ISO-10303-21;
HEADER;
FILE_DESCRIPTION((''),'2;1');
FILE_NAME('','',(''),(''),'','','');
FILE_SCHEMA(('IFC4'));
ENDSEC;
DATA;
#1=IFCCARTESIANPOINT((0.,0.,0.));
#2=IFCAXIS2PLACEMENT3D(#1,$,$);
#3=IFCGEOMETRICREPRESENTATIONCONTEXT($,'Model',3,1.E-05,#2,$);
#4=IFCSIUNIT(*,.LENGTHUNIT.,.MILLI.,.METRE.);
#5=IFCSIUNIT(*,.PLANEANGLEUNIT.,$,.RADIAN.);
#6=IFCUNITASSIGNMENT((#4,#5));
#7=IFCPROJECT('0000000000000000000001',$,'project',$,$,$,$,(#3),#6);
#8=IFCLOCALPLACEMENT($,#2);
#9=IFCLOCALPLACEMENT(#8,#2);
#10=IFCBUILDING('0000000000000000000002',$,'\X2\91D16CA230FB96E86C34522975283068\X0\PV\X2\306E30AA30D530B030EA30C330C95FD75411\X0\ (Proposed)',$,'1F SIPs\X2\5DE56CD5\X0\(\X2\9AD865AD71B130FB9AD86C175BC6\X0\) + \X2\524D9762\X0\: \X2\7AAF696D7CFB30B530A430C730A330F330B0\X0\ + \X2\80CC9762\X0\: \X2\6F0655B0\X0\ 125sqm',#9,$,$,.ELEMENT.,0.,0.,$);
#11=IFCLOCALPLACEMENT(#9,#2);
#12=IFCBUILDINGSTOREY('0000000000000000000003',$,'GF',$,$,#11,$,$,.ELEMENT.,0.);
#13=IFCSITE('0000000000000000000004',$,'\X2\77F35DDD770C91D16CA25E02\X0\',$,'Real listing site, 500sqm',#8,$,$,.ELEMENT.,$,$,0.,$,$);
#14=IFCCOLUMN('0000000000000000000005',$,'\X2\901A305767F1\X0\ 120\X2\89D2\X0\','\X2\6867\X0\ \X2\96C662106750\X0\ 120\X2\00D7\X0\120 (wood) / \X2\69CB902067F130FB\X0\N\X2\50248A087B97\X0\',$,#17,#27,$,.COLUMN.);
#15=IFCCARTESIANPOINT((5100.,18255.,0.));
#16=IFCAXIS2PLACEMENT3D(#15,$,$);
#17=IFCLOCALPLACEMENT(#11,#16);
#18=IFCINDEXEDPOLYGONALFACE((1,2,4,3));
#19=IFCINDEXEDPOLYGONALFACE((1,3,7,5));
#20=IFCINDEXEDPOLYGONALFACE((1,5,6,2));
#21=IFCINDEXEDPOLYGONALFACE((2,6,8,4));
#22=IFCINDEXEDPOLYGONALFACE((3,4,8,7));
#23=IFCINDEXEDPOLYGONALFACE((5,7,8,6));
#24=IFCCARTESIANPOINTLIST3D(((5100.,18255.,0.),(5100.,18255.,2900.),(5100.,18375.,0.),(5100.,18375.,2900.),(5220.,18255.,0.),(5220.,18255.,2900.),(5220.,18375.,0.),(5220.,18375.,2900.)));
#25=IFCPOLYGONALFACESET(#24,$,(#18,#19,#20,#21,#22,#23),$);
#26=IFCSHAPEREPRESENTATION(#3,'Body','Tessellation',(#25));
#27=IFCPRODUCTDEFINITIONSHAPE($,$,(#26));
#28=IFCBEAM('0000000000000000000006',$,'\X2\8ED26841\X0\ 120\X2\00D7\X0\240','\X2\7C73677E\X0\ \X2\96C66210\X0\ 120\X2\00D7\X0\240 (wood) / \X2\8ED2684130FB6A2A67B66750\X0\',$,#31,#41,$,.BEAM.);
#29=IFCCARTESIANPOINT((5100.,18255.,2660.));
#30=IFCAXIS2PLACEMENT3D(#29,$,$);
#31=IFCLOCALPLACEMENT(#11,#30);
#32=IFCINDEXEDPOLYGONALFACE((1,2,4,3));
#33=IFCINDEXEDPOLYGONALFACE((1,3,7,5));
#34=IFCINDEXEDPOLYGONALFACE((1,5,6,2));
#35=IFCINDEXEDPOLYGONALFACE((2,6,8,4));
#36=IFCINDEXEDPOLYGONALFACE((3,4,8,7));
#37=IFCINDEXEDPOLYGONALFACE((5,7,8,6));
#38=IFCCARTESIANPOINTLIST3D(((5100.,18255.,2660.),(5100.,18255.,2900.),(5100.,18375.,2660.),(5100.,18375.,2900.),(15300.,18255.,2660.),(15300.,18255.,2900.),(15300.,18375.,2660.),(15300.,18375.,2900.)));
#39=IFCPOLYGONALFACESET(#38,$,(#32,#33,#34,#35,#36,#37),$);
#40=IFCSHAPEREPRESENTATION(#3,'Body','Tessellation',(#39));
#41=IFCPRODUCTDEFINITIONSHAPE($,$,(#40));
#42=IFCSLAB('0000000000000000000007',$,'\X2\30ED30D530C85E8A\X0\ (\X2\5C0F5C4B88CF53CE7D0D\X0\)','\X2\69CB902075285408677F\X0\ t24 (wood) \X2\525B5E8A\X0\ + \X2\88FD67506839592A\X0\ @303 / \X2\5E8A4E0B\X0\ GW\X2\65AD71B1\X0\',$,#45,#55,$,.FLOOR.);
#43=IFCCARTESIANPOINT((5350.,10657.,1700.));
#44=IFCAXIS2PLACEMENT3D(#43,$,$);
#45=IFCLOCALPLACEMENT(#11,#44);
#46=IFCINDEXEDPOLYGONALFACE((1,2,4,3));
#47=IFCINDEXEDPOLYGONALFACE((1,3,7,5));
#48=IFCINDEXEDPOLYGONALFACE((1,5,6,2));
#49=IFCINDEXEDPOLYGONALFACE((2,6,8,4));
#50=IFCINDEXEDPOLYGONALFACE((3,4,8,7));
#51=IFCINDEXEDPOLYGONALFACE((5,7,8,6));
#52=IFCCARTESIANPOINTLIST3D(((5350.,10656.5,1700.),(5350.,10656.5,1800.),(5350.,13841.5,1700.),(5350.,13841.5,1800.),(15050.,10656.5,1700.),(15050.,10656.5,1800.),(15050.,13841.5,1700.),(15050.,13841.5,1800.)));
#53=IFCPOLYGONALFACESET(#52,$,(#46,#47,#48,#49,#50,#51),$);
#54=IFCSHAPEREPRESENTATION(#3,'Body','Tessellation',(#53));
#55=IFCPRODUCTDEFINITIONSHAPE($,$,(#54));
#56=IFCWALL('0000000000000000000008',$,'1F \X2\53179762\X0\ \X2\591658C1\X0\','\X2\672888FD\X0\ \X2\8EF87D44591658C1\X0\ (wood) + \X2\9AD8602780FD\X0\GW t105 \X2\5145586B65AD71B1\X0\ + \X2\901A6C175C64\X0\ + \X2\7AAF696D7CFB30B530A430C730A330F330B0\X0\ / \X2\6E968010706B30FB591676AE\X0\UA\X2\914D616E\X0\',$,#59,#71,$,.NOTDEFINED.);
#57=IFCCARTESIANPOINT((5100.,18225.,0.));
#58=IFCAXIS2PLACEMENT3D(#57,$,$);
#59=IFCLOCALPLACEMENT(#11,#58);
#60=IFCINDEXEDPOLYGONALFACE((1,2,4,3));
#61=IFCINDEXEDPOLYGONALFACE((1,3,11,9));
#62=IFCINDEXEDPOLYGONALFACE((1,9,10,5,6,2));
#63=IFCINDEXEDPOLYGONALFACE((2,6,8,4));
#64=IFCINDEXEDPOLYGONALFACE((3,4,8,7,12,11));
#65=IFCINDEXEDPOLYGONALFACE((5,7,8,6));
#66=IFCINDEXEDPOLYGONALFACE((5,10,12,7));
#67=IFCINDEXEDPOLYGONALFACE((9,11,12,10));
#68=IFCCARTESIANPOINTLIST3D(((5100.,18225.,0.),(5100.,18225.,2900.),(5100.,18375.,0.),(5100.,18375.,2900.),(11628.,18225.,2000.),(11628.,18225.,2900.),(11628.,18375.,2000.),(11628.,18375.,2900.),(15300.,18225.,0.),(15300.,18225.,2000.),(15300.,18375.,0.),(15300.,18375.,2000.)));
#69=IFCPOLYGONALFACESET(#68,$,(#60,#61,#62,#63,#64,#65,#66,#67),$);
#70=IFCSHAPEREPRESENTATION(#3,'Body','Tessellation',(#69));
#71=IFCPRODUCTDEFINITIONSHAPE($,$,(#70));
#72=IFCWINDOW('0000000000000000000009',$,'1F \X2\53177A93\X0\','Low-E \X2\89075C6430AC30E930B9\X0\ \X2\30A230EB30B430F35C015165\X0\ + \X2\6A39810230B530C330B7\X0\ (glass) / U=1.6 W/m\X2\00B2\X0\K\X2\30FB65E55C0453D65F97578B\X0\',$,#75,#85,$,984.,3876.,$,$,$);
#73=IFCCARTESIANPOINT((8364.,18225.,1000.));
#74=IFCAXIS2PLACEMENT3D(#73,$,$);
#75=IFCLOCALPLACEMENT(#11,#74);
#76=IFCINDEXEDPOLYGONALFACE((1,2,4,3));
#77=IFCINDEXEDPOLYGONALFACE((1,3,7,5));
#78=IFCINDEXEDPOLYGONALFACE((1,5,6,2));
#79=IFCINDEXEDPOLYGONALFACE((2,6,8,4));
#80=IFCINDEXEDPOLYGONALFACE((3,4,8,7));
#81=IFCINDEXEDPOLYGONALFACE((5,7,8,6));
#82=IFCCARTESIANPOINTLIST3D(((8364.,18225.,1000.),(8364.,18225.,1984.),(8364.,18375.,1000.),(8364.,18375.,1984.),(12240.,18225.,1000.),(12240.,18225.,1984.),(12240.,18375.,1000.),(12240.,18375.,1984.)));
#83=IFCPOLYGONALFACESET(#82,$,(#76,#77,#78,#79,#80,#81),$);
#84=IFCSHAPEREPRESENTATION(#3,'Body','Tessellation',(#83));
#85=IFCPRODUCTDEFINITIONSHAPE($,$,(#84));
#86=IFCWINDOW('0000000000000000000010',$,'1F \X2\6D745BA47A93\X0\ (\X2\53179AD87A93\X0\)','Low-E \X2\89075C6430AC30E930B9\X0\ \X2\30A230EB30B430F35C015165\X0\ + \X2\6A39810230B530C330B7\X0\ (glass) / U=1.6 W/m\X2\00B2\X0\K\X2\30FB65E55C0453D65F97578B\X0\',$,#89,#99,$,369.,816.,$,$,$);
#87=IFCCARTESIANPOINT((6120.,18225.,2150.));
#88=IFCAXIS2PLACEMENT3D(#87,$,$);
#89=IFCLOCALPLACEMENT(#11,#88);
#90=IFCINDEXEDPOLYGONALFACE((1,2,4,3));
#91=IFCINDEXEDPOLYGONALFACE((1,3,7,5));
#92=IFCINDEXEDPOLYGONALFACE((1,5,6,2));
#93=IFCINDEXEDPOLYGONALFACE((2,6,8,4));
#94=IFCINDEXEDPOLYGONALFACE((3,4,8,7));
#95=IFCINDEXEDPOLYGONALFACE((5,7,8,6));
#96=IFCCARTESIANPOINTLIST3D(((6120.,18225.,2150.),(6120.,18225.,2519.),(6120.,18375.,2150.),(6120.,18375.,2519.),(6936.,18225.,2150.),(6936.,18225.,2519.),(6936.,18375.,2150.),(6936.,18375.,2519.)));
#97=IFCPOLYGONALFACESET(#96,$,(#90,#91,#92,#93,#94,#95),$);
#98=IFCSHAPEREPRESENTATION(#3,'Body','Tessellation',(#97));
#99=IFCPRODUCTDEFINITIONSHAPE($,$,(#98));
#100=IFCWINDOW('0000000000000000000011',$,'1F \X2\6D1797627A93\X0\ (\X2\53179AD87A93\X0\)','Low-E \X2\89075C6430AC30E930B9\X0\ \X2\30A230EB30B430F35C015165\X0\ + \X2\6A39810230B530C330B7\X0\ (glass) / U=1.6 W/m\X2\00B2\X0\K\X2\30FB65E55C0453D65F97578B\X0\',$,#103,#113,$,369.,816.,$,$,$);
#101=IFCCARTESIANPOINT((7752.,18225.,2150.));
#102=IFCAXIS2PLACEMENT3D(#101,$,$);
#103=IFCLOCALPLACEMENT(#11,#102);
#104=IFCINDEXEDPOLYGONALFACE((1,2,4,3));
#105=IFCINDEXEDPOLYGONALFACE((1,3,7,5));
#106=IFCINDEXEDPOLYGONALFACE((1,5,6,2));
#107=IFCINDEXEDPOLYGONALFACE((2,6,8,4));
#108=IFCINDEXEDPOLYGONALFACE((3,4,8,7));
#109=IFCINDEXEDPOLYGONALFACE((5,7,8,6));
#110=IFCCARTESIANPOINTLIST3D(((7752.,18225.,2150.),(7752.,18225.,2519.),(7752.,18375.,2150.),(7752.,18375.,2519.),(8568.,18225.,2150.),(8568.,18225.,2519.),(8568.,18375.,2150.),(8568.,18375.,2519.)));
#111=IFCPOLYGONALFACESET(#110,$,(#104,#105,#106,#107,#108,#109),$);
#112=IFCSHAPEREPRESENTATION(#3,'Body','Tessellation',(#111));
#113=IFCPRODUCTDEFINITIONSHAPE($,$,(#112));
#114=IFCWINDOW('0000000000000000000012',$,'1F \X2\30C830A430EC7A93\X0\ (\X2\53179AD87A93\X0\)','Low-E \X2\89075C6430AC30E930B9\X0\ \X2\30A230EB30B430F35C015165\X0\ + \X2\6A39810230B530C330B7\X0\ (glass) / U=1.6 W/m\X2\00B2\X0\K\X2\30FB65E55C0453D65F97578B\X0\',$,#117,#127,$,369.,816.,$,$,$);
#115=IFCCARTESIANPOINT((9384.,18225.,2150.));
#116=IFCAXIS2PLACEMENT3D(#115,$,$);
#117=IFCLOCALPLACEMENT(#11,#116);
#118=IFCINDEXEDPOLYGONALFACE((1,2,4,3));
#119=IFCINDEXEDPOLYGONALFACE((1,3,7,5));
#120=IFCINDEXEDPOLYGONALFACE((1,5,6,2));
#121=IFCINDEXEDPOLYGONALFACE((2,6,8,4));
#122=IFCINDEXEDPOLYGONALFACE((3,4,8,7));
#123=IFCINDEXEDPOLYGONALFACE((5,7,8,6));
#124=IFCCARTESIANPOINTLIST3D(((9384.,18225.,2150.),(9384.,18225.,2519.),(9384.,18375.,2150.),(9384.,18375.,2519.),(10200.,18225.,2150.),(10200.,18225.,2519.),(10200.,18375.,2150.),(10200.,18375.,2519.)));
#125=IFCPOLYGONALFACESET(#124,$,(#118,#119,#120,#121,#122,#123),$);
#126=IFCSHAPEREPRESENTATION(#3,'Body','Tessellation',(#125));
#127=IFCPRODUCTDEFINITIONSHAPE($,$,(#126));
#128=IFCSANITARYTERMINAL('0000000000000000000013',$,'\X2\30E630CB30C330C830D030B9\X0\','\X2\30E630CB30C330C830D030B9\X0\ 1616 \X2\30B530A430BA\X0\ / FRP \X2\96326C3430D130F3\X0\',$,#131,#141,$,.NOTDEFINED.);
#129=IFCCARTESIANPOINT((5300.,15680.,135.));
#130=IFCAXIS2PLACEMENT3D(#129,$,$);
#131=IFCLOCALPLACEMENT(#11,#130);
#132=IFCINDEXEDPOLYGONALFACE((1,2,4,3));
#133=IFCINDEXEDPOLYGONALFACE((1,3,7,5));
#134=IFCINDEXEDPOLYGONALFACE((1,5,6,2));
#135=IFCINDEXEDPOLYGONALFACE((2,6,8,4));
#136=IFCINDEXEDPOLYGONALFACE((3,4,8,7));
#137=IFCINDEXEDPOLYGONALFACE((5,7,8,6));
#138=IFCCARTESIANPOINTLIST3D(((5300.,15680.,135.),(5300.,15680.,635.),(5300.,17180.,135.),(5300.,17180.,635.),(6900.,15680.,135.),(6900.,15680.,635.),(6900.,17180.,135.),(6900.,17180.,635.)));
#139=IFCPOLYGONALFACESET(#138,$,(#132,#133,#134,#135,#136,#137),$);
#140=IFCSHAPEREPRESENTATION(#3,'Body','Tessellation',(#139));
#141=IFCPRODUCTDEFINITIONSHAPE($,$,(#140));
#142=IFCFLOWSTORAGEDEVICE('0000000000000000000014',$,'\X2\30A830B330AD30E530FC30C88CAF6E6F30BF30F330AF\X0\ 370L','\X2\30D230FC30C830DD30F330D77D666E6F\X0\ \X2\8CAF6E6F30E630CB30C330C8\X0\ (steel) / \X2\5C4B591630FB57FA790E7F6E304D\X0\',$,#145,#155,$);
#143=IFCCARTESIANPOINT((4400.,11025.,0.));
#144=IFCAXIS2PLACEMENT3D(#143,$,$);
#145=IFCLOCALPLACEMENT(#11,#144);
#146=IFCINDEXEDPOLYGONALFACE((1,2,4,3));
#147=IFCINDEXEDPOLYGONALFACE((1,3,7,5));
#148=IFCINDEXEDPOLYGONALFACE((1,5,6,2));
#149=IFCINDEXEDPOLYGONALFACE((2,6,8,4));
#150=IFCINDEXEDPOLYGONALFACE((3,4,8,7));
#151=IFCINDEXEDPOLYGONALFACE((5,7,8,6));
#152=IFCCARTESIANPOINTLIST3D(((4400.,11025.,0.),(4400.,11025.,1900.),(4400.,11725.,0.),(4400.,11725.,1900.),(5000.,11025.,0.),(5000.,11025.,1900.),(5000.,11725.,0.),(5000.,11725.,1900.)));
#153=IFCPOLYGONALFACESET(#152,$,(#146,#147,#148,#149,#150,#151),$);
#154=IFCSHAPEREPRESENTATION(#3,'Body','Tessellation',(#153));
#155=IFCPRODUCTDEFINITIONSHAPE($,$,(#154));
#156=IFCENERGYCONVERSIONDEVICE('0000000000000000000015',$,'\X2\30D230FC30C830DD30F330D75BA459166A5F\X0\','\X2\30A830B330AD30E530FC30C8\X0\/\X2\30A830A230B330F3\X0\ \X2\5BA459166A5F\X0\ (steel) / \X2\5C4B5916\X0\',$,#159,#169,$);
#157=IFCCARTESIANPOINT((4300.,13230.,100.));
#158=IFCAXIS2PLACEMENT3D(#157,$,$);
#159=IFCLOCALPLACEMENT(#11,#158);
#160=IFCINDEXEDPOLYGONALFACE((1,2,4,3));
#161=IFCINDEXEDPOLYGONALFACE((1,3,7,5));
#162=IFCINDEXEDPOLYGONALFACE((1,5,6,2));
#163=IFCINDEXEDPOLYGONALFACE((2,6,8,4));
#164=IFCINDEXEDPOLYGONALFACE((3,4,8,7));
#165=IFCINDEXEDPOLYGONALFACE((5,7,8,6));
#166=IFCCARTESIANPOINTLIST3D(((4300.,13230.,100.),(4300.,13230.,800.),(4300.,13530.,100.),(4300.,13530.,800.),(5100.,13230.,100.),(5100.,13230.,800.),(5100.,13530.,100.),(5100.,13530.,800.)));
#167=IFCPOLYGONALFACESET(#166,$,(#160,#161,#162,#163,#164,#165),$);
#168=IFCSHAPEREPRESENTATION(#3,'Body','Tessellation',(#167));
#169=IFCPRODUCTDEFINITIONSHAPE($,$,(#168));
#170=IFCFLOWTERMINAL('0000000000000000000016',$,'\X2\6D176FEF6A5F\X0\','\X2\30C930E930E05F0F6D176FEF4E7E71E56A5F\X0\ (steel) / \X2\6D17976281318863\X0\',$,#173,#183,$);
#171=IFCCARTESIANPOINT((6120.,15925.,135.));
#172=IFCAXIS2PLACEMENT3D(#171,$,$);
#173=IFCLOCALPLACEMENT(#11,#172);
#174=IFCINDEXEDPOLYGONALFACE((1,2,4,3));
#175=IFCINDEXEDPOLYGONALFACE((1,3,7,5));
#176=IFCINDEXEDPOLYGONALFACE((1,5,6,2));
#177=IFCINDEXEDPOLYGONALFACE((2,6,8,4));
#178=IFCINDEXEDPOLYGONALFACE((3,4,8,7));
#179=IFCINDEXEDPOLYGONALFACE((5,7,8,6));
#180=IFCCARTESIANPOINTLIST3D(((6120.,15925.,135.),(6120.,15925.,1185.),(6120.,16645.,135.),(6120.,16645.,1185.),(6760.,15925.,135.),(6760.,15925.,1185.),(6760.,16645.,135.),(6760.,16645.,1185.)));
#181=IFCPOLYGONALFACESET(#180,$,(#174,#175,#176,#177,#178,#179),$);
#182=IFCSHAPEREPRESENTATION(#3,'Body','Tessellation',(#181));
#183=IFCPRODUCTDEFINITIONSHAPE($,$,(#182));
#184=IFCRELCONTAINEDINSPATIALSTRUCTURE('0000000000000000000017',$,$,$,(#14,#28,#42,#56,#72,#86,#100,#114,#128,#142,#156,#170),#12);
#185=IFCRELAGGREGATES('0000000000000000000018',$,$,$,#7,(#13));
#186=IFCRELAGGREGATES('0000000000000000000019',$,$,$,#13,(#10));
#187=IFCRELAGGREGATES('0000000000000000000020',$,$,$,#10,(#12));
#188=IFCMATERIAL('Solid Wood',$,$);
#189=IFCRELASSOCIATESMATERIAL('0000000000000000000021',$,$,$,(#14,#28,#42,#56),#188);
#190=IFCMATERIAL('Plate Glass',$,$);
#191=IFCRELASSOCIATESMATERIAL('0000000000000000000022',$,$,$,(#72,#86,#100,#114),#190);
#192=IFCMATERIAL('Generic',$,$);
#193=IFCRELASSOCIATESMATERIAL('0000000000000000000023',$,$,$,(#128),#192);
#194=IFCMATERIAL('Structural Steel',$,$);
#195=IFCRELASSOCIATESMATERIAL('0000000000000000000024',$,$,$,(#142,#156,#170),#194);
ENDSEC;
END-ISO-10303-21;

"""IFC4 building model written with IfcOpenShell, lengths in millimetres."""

from ifc_helpers import new_model, si_unit, frame, frame_2d, origin, place, context, project, spatial, rectangle, extrude, material, element, fill, save


model = new_model("IFC4")

# Units and contexts
model_context = context("Model", 3, precision=1e-05, world=origin())
ifc_project = project(units=[si_unit("LENGTHUNIT", "METRE", prefix="MILLI"), si_unit("PLANEANGLEUNIT", "RADIAN")], contexts=[model_context])

# Site, building, storey
site_placement = place(None, origin())
site = spatial("IfcSite", under=ifc_project, at=site_placement, Name="石川県金沢市", ObjectType="Real listing site, 500sqm", CompositionType="ELEMENT", RefElevation=0.0)
building_placement = place(site_placement, origin())
building = spatial("IfcBuilding", under=site, at=building_placement, Name="金沢・雨水利用とPVのオフグリッド志向 (Proposed)", ObjectType="1F SIPs工法(高断熱・高気密) + 前面: 窯業系サイディング + 背面: 漆喰 125sqm", CompositionType="ELEMENT", ElevationOfRefHeight=0.0, ElevationOfTerrain=0.0)
storey_placement = place(building_placement, origin())
storey = spatial("IfcBuildingStorey", under=building, at=storey_placement, Name="GF", CompositionType="ELEMENT", Elevation=0.0)

# Column
ifc_material_1 = material(Name="Solid Wood")
column_1_placement = place(storey_placement, frame((5100.0, 18255.0, 0.0)))
element("IfcColumn", 1, at=column_1_placement, inside=storey, material=ifc_material_1, Name="通し柱 120角", Description="桧 集成材 120×120 (wood) / 構造柱・N値計算", PredefinedType="COLUMN", context=model_context, shape_type="SweptSolid", body=[
    extrude(rectangle(XDim=120.0, YDim=120.0, at=frame_2d((60.0, 60.0))), frame((5100.0, 18255.0, 0.0)), (0.0, 0.0, 1.0), 2900.0),
])

# Beam
beam_1_placement = place(storey_placement, frame((5100.0, 18255.0, 2660.0)))
element("IfcBeam", 2, at=beam_1_placement, inside=storey, material=ifc_material_1, Name="軒桁 120×240", Description="米松 集成 120×240 (wood) / 軒桁・横架材", PredefinedType="BEAM", context=model_context, shape_type="SweptSolid", body=[
    extrude(rectangle(XDim=10200.0, YDim=120.0, at=frame_2d((5100.0, 60.0))), frame((5100.0, 18255.0, 2660.0)), (0.0, 0.0, 1.0), 240.0),
])

# Slab
slab_placement = place(storey_placement, frame((5350.0, 10657.0, 1700.0)))
element("IfcSlab", 3, at=slab_placement, inside=storey, material=ifc_material_1, Name="ロフト床 (小屋裏収納)", Description="構造用合板 t24 (wood) 剛床 + 製材根太 @303 / 床下 GW断熱", PredefinedType="FLOOR", context=model_context, shape_type="SweptSolid", body=[
    extrude(rectangle(XDim=9700.0, YDim=3185.0, at=frame_2d((4850.0, 1592.0))), frame((5350.0, 10657.0, 1700.0)), (0.0, 0.0, 1.0), 100.0),
])

# Wall, openings, windows
wall_1_placement = place(storey_placement, frame((5100.0, 18225.0, 0.0)))
wall_1 = element("IfcWall", 4, at=wall_1_placement, inside=storey, material=ifc_material_1, Name="1F 北面 外壁", Description="木製 軸組外壁 (wood) + 高性能GW t105 充填断熱 + 通気層 + 窯業系サイディング / 準耐火・外皮UA配慮", PredefinedType="NOTDEFINED", context=model_context, shape_type="SweptSolid", body=[
    extrude(rectangle(XDim=10200.0, YDim=150.0, at=frame_2d((5100.0, 75.0))), frame((5100.0, 18225.0, 0.0)), (0.0, 0.0, 1.0), 2900.0),
])
opening_1_placement = place(storey_placement, frame((8364.0, 18225.0, 1000.0)))
opening_1 = element("IfcOpeningElement", 5, at=opening_1_placement, cuts=wall_1, PredefinedType="NOTDEFINED", context=model_context, shape_type="SweptSolid", body=[
    extrude(rectangle(XDim=3876.0, YDim=150.0, at=frame_2d((1938.0, 75.0))), frame((8364.0, 18225.0, 1000.0)), (0.0, 0.0, 1.0), 984.0),
])
opening_2_placement = place(storey_placement, frame((6120.0, 18225.0, 2150.0)))
opening_2 = element("IfcOpeningElement", 6, at=opening_2_placement, cuts=wall_1, PredefinedType="NOTDEFINED", context=model_context, shape_type="SweptSolid", body=[
    extrude(rectangle(XDim=816.0, YDim=150.0, at=frame_2d((408.0, 75.0))), frame((6120.0, 18225.0, 2150.0)), (0.0, 0.0, 1.0), 369.0),
])
opening_3_placement = place(storey_placement, frame((7752.0, 18225.0, 2150.0)))
opening_3 = element("IfcOpeningElement", 7, at=opening_3_placement, cuts=wall_1, PredefinedType="NOTDEFINED", context=model_context, shape_type="SweptSolid", body=[
    extrude(rectangle(XDim=816.0, YDim=150.0, at=frame_2d((408.0, 75.0))), frame((7752.0, 18225.0, 2150.0)), (0.0, 0.0, 1.0), 369.0),
])
opening_4_placement = place(storey_placement, frame((9384.0, 18225.0, 2150.0)))
opening_4 = element("IfcOpeningElement", 8, at=opening_4_placement, cuts=wall_1, PredefinedType="NOTDEFINED", context=model_context, shape_type="SweptSolid", body=[
    extrude(rectangle(XDim=816.0, YDim=150.0, at=frame_2d((408.0, 75.0))), frame((9384.0, 18225.0, 2150.0)), (0.0, 0.0, 1.0), 369.0),
])
ifc_material_2 = material(Name="Plate Glass")
window_1_placement = place(storey_placement, frame((8364.0, 18225.0, 1000.0)))
window_1 = element("IfcWindow", 9, at=window_1_placement, inside=storey, material=ifc_material_2, Name="1F 北窓", Description="Low-E 複層ガラス アルゴン封入 + 樹脂サッシ (glass) / U=1.6 W/m²K・日射取得型", OverallHeight=984.0, OverallWidth=3876.0, context=model_context, shape_type="SweptSolid", body=[
    extrude(rectangle(XDim=3876.0, YDim=150.0, at=frame_2d((1938.0, 75.0))), frame((8364.0, 18225.0, 1000.0)), (0.0, 0.0, 1.0), 984.0),
])
fill(opening_1, window_1)
window_2_placement = place(storey_placement, frame((6120.0, 18225.0, 2150.0)))
window_2 = element("IfcWindow", 10, at=window_2_placement, inside=storey, material=ifc_material_2, Name="1F 浴室窓 (北高窓)", Description="Low-E 複層ガラス アルゴン封入 + 樹脂サッシ (glass) / U=1.6 W/m²K・日射取得型", OverallHeight=369.0, OverallWidth=816.0, context=model_context, shape_type="SweptSolid", body=[
    extrude(rectangle(XDim=816.0, YDim=150.0, at=frame_2d((408.0, 75.0))), frame((6120.0, 18225.0, 2150.0)), (0.0, 0.0, 1.0), 369.0),
])
fill(opening_2, window_2)
window_3_placement = place(storey_placement, frame((7752.0, 18225.0, 2150.0)))
window_3 = element("IfcWindow", 11, at=window_3_placement, inside=storey, material=ifc_material_2, Name="1F 洗面窓 (北高窓)", Description="Low-E 複層ガラス アルゴン封入 + 樹脂サッシ (glass) / U=1.6 W/m²K・日射取得型", OverallHeight=369.0, OverallWidth=816.0, context=model_context, shape_type="SweptSolid", body=[
    extrude(rectangle(XDim=816.0, YDim=150.0, at=frame_2d((408.0, 75.0))), frame((7752.0, 18225.0, 2150.0)), (0.0, 0.0, 1.0), 369.0),
])
fill(opening_3, window_3)
window_4_placement = place(storey_placement, frame((9384.0, 18225.0, 2150.0)))
window_4 = element("IfcWindow", 12, at=window_4_placement, inside=storey, material=ifc_material_2, Name="1F トイレ窓 (北高窓)", Description="Low-E 複層ガラス アルゴン封入 + 樹脂サッシ (glass) / U=1.6 W/m²K・日射取得型", OverallHeight=369.0, OverallWidth=816.0, context=model_context, shape_type="SweptSolid", body=[
    extrude(rectangle(XDim=816.0, YDim=150.0, at=frame_2d((408.0, 75.0))), frame((9384.0, 18225.0, 2150.0)), (0.0, 0.0, 1.0), 369.0),
])
fill(opening_4, window_4)

# Sanitary terminal
ifc_material_3 = material(Name="Generic")
sanitary_terminal_placement = place(storey_placement, frame((5300.0, 15680.0, 135.0)))
element("IfcSanitaryTerminal", 13, at=sanitary_terminal_placement, inside=storey, material=ifc_material_3, Name="ユニットバス", Description="ユニットバス 1616 サイズ / FRP 防水パン", PredefinedType="NOTDEFINED", context=model_context, shape_type="SweptSolid", body=[
    extrude(rectangle(XDim=1600.0, YDim=1500.0, at=frame_2d((800.0, 750.0))), frame((5300.0, 15680.0, 135.0)), (0.0, 0.0, 1.0), 500.0),
])

# Flow storage device
ifc_material_4 = material(Name="Structural Steel")
flow_storage_device_placement = place(storey_placement, frame((4400.0, 11025.0, 0.0)))
element("IfcFlowStorageDevice", 14, at=flow_storage_device_placement, inside=storey, material=ifc_material_4, Name="エコキュート貯湯タンク 370L", Description="ヒートポンプ給湯 貯湯ユニット (steel) / 屋外・基礎置き", context=model_context, shape_type="SweptSolid", body=[
    extrude(rectangle(XDim=600.0, YDim=700.0, at=frame_2d((300.0, 350.0))), frame((4400.0, 11025.0, 0.0)), (0.0, 0.0, 1.0), 1900.0),
])

# Energy conversion device
energy_conversion_device_placement = place(storey_placement, frame((4300.0, 13230.0, 100.0)))
element("IfcEnergyConversionDevice", 15, at=energy_conversion_device_placement, inside=storey, material=ifc_material_4, Name="ヒートポンプ室外機", Description="エコキュート/エアコン 室外機 (steel) / 屋外", context=model_context, shape_type="SweptSolid", body=[
    extrude(rectangle(XDim=800.0, YDim=300.0, at=frame_2d((400.0, 150.0))), frame((4300.0, 13230.0, 100.0)), (0.0, 0.0, 1.0), 700.0),
])

# Flow terminal
flow_terminal_placement = place(storey_placement, frame((6120.0, 15925.0, 135.0)))
element("IfcFlowTerminal", 16, at=flow_terminal_placement, inside=storey, material=ifc_material_4, Name="洗濯機", Description="ドラム式洗濯乾燥機 (steel) / 洗面脱衣", context=model_context, shape_type="SweptSolid", body=[
    extrude(rectangle(XDim=640.0, YDim=720.0, at=frame_2d((320.0, 360.0))), frame((6120.0, 15925.0, 135.0)), (0.0, 0.0, 1.0), 1050.0),
])

save(model, "model.ifc")
